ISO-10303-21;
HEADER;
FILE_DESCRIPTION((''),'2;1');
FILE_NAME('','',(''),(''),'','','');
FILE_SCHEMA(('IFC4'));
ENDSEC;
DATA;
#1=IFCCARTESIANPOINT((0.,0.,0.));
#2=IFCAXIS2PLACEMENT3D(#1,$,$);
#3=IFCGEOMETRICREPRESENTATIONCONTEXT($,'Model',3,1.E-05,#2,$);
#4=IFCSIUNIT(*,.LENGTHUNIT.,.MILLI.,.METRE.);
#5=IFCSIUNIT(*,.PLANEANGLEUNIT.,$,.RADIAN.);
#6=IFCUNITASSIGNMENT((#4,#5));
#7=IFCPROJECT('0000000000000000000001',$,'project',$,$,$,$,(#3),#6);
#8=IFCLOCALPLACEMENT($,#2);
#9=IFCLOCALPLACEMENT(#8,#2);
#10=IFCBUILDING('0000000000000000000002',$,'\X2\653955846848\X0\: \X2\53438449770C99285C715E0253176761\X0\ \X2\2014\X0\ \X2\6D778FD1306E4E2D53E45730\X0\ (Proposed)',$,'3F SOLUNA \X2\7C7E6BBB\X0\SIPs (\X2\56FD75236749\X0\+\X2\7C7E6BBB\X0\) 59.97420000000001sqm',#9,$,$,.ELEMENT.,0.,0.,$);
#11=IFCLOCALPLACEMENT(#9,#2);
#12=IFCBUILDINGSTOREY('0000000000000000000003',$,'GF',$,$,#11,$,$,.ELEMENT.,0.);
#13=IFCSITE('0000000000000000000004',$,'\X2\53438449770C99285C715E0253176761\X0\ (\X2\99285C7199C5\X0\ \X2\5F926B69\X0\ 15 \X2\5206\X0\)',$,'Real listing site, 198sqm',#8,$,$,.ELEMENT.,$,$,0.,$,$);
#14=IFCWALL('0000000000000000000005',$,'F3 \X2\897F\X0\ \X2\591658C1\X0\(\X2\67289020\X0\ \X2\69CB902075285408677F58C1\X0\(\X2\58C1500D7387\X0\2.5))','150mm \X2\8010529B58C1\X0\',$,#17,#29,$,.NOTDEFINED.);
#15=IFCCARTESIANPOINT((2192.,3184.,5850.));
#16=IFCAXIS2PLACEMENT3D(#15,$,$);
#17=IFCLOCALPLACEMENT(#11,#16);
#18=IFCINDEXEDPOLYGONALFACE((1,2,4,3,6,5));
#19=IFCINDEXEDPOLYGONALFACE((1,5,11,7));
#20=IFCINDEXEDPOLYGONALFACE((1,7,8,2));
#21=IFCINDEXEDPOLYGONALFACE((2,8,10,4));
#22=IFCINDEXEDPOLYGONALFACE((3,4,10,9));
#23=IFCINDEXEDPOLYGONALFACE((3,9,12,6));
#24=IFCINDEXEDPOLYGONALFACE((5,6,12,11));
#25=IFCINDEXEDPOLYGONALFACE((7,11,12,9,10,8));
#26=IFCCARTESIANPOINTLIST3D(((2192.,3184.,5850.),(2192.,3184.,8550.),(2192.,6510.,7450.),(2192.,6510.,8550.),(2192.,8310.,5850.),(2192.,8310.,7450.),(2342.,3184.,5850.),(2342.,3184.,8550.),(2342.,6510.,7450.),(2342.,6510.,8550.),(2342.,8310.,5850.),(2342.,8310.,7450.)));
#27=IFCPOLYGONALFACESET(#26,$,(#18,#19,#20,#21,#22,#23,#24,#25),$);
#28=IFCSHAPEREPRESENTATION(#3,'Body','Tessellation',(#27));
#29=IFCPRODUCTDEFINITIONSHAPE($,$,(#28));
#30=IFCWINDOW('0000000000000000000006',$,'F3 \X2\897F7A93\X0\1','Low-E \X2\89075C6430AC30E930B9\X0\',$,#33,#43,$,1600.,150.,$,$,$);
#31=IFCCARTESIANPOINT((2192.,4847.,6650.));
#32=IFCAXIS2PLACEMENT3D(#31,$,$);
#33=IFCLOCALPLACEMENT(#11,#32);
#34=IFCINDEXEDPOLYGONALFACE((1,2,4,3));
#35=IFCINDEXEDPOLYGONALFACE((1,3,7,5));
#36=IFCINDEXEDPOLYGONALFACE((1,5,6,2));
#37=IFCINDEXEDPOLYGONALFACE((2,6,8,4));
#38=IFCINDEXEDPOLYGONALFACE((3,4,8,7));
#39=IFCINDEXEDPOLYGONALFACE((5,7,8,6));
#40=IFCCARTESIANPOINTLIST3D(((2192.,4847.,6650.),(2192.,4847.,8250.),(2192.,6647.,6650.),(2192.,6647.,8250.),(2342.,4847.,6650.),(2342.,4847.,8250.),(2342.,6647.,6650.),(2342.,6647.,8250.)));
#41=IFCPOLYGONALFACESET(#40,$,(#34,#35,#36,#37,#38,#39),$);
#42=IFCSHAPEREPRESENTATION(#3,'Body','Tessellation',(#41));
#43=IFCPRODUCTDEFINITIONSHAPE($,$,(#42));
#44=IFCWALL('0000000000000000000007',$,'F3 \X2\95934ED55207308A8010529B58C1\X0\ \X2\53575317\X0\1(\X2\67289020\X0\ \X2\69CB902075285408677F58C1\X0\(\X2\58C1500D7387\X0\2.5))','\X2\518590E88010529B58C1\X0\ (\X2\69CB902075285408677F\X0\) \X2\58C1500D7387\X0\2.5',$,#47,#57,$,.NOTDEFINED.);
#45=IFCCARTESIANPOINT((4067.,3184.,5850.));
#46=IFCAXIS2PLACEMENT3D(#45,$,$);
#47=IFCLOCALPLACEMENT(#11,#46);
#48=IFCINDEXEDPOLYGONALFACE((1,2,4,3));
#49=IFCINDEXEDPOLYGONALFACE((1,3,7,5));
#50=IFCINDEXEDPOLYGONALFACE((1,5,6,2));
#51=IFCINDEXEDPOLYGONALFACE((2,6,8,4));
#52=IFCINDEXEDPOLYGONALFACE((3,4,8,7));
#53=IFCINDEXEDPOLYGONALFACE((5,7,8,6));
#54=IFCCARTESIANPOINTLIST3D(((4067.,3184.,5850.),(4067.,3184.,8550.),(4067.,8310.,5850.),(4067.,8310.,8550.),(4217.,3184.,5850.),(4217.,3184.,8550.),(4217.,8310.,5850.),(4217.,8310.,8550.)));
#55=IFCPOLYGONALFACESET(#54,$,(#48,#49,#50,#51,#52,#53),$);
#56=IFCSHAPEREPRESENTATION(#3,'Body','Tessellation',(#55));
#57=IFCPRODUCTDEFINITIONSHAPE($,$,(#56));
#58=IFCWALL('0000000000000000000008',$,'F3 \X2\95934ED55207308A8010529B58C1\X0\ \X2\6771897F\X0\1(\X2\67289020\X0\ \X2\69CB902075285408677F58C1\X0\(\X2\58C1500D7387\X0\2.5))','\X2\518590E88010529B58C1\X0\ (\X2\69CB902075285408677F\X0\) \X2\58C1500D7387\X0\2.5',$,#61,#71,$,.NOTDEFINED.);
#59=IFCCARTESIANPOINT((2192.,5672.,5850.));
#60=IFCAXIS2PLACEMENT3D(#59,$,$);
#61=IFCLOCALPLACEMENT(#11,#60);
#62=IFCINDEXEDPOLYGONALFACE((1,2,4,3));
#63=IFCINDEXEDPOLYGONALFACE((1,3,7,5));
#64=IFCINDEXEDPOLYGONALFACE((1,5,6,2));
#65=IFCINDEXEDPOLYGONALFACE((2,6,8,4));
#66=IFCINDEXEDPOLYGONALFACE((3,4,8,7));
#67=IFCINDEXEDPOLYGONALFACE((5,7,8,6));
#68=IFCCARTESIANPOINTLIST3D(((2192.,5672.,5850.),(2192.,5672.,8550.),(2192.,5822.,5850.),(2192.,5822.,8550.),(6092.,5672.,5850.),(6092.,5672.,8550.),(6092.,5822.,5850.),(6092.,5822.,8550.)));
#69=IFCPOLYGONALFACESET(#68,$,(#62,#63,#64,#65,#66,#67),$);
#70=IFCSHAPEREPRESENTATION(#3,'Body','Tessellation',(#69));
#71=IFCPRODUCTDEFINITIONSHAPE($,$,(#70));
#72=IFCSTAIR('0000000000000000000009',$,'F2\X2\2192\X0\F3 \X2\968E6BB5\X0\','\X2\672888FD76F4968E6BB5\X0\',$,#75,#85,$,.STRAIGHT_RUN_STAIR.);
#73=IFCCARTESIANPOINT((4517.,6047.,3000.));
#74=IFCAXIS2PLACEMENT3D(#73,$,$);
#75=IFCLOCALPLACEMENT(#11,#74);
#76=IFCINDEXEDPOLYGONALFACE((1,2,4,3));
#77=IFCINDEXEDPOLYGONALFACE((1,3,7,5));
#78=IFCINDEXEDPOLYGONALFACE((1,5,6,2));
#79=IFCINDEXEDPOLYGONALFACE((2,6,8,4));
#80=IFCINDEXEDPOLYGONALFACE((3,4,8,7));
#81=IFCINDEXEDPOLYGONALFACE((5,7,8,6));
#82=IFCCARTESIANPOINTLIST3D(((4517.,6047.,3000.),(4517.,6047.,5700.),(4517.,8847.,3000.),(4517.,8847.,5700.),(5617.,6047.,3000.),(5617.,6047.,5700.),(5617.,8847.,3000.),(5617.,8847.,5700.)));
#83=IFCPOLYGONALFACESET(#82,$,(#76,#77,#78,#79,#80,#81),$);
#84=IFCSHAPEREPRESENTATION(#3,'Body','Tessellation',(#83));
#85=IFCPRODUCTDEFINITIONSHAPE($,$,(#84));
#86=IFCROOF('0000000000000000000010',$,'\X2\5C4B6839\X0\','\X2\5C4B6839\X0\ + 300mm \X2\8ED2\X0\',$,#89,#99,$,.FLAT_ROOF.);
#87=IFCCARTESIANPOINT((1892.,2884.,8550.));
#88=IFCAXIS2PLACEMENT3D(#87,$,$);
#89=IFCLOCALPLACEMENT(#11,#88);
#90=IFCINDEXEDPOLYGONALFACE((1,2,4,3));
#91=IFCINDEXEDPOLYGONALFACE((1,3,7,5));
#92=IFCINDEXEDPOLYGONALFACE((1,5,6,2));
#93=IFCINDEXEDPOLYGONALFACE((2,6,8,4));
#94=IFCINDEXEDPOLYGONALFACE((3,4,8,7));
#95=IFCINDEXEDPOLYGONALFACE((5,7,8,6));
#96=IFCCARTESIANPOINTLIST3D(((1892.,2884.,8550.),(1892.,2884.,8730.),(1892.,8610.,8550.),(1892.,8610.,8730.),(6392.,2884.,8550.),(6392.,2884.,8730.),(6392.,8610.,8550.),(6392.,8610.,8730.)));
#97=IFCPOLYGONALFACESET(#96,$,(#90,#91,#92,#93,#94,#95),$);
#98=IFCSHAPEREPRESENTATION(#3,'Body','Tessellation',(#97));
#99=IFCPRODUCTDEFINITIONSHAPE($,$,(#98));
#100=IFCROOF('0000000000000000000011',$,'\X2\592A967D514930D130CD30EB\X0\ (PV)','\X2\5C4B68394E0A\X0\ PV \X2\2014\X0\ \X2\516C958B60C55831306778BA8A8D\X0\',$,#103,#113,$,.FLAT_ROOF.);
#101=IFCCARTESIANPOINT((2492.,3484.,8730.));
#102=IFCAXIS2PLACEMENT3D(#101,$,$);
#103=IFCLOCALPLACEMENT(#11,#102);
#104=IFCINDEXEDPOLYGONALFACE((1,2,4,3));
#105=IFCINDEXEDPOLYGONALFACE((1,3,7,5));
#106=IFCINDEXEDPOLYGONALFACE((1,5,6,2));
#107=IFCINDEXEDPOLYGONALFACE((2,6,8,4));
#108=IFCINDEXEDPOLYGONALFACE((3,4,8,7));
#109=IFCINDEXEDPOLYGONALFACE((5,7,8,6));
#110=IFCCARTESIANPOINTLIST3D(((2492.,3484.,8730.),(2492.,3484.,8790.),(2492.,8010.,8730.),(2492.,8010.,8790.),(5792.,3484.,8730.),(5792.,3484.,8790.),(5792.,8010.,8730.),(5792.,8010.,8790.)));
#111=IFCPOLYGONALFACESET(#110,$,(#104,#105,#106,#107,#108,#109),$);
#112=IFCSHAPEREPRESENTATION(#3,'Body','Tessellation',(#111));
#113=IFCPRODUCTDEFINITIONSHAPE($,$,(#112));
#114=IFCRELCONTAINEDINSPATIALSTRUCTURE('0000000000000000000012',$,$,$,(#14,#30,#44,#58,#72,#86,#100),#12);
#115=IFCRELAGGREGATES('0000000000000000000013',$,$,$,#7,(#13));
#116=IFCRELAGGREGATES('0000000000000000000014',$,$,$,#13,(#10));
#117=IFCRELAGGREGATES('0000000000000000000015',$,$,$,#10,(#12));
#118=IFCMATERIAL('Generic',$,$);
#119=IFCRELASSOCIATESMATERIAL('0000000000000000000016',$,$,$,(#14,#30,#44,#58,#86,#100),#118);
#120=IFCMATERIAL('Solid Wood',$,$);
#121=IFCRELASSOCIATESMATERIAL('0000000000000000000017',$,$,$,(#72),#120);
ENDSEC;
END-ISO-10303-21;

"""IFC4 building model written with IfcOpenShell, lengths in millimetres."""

from ifc_helpers import new_model, si_unit, frame, frame_2d, origin, place, context, project, spatial, rectangle, extrude, material, element, fill, save


model = new_model("IFC4")

# Units and contexts
model_context = context("Model", 3, precision=1e-05, world=origin())
ifc_project = project(units=[si_unit("LENGTHUNIT", "METRE", prefix="MILLI"), si_unit("PLANEANGLEUNIT", "RADIAN")], contexts=[model_context])

# Site, building, storey
site_placement = place(None, origin())
site = spatial("IfcSite", under=ifc_project, at=site_placement, Name="千葉県館山市北条 (館山駅 徒歩 15 分)", ObjectType="Real listing site, 198sqm", CompositionType="ELEMENT", RefElevation=0.0)
building_placement = place(site_placement, origin())
building = spatial("IfcBuilding", under=site, at=building_placement, Name="改善案: 千葉県館山市北条 — 海近の中古地 (Proposed)", ObjectType="3F SOLUNA 籾殻SIPs (国産杉+籾殻) 59.97420000000001sqm", CompositionType="ELEMENT", ElevationOfRefHeight=0.0, ElevationOfTerrain=0.0)
storey_placement = place(building_placement, origin())
storey = spatial("IfcBuildingStorey", under=building, at=storey_placement, Name="GF", CompositionType="ELEMENT", Elevation=0.0)

# Shared definitions
ifc_material_1 = material(Name="Generic")

# Wall, opening, window
wall_1_placement = place(storey_placement, frame((2192.0, 3184.0, 5850.0)))
wall_1 = element("IfcWall", 1, at=wall_1_placement, inside=storey, material=ifc_material_1, Name="F3 西 外壁(木造 構造用合板壁(壁倍率2.5))", Description="150mm 耐力壁", PredefinedType="NOTDEFINED", context=model_context, shape_type="SweptSolid", body=[
    extrude(rectangle(XDim=150.0, YDim=5126.0, at=frame_2d((75.0, 2563.0))), frame((2192.0, 3184.0, 5850.0)), (0.0, 0.0, 1.0), 2700.0),
])
opening_1_placement = place(storey_placement, frame((2192.0, 4847.0, 6650.0)))
opening_1 = element("IfcOpeningElement", 2, at=opening_1_placement, cuts=wall_1, PredefinedType="NOTDEFINED", context=model_context, shape_type="SweptSolid", body=[
    extrude(rectangle(XDim=150.0, YDim=1800.0, at=frame_2d((75.0, 900.0))), frame((2192.0, 4847.0, 6650.0)), (0.0, 0.0, 1.0), 1600.0),
])
window_1_placement = place(storey_placement, frame((2192.0, 4847.0, 6650.0)))
window_1 = element("IfcWindow", 3, at=window_1_placement, inside=storey, material=ifc_material_1, Name="F3 西窓1", Description="Low-E 複層ガラス", OverallHeight=1600.0, OverallWidth=150.0, context=model_context, shape_type="SweptSolid", body=[
    extrude(rectangle(XDim=150.0, YDim=1800.0, at=frame_2d((75.0, 900.0))), frame((2192.0, 4847.0, 6650.0)), (0.0, 0.0, 1.0), 1600.0),
])
fill(opening_1, window_1)

# Walls
wall_2_placement = place(storey_placement, frame((4067.0, 3184.0, 5850.0)))
element("IfcWall", 4, at=wall_2_placement, inside=storey, material=ifc_material_1, Name="F3 間仕切り耐力壁 南北1(木造 構造用合板壁(壁倍率2.5))", Description="内部耐力壁 (構造用合板) 壁倍率2.5", PredefinedType="NOTDEFINED", context=model_context, shape_type="SweptSolid", body=[
    extrude(rectangle(XDim=150.0, YDim=5126.0, at=frame_2d((75.0, 2563.0))), frame((4067.0, 3184.0, 5850.0)), (0.0, 0.0, 1.0), 2700.0),
])
wall_3_placement = place(storey_placement, frame((2192.0, 5672.0, 5850.0)))
element("IfcWall", 5, at=wall_3_placement, inside=storey, material=ifc_material_1, Name="F3 間仕切り耐力壁 東西1(木造 構造用合板壁(壁倍率2.5))", Description="内部耐力壁 (構造用合板) 壁倍率2.5", PredefinedType="NOTDEFINED", context=model_context, shape_type="SweptSolid", body=[
    extrude(rectangle(XDim=3900.0, YDim=150.0, at=frame_2d((1950.0, 75.0))), frame((2192.0, 5672.0, 5850.0)), (0.0, 0.0, 1.0), 2700.0),
])

# Stair
ifc_material_2 = material(Name="Solid Wood")
stair_placement = place(storey_placement, frame((4517.0, 6047.0, 3000.0)))
element("IfcStair", 6, at=stair_placement, inside=storey, material=ifc_material_2, Name="F2→F3 階段", Description="木製直階段", PredefinedType="STRAIGHT_RUN_STAIR", context=model_context, shape_type="SweptSolid", body=[
    extrude(rectangle(XDim=1100.0, YDim=2800.0, at=frame_2d((550.0, 1400.0))), frame((4517.0, 6047.0, 3000.0)), (0.0, 0.0, 1.0), 2700.0),
])

# Roofs
roof_1_placement = place(storey_placement, frame((1892.0, 2884.0, 8550.0)))
element("IfcRoof", 7, at=roof_1_placement, inside=storey, material=ifc_material_1, Name="屋根", Description="屋根 + 300mm 軒", PredefinedType="FLAT_ROOF", context=model_context, shape_type="SweptSolid", body=[
    extrude(rectangle(XDim=4500.0, YDim=5726.0, at=frame_2d((2250.0, 2863.0))), frame((1892.0, 2884.0, 8550.0)), (0.0, 0.0, 1.0), 180.0),
])
roof_2_placement = place(storey_placement, frame((2492.0, 3484.0, 8730.0)))
element("IfcRoof", 8, at=roof_2_placement, inside=storey, material=ifc_material_1, Name="太陽光パネル (PV)", Description="屋根上 PV — 公開情報で確認", PredefinedType="FLAT_ROOF", context=model_context, shape_type="SweptSolid", body=[
    extrude(rectangle(XDim=3300.0, YDim=4526.0, at=frame_2d((1650.0, 2263.0))), frame((2492.0, 3484.0, 8730.0)), (0.0, 0.0, 1.0), 60.0),
])

save(model, "model.ifc")
